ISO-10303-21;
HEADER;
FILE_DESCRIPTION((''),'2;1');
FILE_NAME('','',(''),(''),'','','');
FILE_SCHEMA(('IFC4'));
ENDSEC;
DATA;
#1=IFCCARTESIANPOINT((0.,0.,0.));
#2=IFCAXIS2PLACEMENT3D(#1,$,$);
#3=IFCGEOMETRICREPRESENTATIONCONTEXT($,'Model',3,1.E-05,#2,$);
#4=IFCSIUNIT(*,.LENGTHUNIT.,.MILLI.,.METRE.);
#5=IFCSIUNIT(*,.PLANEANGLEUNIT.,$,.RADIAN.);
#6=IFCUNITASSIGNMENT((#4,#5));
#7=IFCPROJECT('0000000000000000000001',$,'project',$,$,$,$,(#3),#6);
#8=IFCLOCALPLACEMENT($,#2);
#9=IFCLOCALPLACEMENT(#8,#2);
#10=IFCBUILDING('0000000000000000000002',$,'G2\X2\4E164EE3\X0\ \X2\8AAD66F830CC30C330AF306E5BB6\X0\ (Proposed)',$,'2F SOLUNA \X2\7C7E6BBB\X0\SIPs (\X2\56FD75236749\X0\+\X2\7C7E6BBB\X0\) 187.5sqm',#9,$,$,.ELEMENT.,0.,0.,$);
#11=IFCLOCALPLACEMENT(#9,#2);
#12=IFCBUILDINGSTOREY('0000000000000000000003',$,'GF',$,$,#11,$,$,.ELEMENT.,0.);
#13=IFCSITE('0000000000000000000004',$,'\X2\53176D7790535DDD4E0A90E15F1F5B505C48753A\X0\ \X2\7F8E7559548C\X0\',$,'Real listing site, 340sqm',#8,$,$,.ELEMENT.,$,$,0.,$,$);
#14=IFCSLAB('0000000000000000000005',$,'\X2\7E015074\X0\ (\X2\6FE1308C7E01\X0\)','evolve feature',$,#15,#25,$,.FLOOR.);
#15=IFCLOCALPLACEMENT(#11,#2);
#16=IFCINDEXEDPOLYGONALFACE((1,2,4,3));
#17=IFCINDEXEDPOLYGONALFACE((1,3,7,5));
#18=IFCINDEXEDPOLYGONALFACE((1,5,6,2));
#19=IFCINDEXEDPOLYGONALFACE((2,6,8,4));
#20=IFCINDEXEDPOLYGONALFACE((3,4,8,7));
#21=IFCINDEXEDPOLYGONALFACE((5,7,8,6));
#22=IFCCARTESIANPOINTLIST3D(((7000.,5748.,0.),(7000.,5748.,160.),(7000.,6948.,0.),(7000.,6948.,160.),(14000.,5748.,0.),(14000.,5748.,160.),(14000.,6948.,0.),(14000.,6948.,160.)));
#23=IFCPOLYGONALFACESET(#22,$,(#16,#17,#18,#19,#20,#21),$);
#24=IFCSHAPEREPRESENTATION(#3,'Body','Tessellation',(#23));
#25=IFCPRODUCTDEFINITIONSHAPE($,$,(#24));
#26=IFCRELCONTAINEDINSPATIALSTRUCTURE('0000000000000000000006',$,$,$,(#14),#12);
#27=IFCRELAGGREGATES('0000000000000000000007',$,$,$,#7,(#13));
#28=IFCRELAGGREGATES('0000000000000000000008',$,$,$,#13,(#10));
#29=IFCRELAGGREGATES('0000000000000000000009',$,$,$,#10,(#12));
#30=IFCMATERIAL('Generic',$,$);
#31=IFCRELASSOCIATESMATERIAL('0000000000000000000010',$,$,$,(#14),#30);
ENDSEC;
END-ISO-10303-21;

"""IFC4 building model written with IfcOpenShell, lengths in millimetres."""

from ifc_helpers import new_model, si_unit, frame, frame_2d, origin, place, context, project, spatial, rectangle, extrude, material, element, save


model = new_model("IFC4")

# Units and contexts
model_context = context("Model", 3, precision=1e-05, world=origin())
ifc_project = project(units=[si_unit("LENGTHUNIT", "METRE", prefix="MILLI"), si_unit("PLANEANGLEUNIT", "RADIAN")], contexts=[model_context])

# Site, building, storey
site_placement = place(None, origin())
site = spatial("IfcSite", under=ifc_project, at=site_placement, Name="北海道川上郡弟子屈町 美留和", ObjectType="Real listing site, 340sqm", CompositionType="ELEMENT", RefElevation=0.0)
building_placement = place(site_placement, origin())
building = spatial("IfcBuilding", under=site, at=building_placement, Name="G2世代 読書ヌックの家 (Proposed)", ObjectType="2F SOLUNA 籾殻SIPs (国産杉+籾殻) 187.5sqm", CompositionType="ELEMENT", ElevationOfRefHeight=0.0, ElevationOfTerrain=0.0)
storey_placement = place(building_placement, origin())
storey = spatial("IfcBuildingStorey", under=building, at=storey_placement, Name="GF", CompositionType="ELEMENT", Elevation=0.0)

# Slab
ifc_material_1 = material(Name="Generic")
slab_1_placement = place(storey_placement, frame((3500.0, 2874.0, 0.0)))
element("IfcSlab", 1, at=slab_1_placement, inside=storey, material=ifc_material_1, Name="縁側 (濡れ縁)", Description="evolve feature", PredefinedType="FLOOR", context=model_context, shape_type="SweptSolid", body=[
    extrude(rectangle(XDim=7000.0, YDim=1200.0, at=frame_2d((3500.0, 600.0))), frame((3500.0, 2874.0, 0.0)), (0.0, 0.0, 1.0), 160.0),
])

save(model, "model.ifc")
